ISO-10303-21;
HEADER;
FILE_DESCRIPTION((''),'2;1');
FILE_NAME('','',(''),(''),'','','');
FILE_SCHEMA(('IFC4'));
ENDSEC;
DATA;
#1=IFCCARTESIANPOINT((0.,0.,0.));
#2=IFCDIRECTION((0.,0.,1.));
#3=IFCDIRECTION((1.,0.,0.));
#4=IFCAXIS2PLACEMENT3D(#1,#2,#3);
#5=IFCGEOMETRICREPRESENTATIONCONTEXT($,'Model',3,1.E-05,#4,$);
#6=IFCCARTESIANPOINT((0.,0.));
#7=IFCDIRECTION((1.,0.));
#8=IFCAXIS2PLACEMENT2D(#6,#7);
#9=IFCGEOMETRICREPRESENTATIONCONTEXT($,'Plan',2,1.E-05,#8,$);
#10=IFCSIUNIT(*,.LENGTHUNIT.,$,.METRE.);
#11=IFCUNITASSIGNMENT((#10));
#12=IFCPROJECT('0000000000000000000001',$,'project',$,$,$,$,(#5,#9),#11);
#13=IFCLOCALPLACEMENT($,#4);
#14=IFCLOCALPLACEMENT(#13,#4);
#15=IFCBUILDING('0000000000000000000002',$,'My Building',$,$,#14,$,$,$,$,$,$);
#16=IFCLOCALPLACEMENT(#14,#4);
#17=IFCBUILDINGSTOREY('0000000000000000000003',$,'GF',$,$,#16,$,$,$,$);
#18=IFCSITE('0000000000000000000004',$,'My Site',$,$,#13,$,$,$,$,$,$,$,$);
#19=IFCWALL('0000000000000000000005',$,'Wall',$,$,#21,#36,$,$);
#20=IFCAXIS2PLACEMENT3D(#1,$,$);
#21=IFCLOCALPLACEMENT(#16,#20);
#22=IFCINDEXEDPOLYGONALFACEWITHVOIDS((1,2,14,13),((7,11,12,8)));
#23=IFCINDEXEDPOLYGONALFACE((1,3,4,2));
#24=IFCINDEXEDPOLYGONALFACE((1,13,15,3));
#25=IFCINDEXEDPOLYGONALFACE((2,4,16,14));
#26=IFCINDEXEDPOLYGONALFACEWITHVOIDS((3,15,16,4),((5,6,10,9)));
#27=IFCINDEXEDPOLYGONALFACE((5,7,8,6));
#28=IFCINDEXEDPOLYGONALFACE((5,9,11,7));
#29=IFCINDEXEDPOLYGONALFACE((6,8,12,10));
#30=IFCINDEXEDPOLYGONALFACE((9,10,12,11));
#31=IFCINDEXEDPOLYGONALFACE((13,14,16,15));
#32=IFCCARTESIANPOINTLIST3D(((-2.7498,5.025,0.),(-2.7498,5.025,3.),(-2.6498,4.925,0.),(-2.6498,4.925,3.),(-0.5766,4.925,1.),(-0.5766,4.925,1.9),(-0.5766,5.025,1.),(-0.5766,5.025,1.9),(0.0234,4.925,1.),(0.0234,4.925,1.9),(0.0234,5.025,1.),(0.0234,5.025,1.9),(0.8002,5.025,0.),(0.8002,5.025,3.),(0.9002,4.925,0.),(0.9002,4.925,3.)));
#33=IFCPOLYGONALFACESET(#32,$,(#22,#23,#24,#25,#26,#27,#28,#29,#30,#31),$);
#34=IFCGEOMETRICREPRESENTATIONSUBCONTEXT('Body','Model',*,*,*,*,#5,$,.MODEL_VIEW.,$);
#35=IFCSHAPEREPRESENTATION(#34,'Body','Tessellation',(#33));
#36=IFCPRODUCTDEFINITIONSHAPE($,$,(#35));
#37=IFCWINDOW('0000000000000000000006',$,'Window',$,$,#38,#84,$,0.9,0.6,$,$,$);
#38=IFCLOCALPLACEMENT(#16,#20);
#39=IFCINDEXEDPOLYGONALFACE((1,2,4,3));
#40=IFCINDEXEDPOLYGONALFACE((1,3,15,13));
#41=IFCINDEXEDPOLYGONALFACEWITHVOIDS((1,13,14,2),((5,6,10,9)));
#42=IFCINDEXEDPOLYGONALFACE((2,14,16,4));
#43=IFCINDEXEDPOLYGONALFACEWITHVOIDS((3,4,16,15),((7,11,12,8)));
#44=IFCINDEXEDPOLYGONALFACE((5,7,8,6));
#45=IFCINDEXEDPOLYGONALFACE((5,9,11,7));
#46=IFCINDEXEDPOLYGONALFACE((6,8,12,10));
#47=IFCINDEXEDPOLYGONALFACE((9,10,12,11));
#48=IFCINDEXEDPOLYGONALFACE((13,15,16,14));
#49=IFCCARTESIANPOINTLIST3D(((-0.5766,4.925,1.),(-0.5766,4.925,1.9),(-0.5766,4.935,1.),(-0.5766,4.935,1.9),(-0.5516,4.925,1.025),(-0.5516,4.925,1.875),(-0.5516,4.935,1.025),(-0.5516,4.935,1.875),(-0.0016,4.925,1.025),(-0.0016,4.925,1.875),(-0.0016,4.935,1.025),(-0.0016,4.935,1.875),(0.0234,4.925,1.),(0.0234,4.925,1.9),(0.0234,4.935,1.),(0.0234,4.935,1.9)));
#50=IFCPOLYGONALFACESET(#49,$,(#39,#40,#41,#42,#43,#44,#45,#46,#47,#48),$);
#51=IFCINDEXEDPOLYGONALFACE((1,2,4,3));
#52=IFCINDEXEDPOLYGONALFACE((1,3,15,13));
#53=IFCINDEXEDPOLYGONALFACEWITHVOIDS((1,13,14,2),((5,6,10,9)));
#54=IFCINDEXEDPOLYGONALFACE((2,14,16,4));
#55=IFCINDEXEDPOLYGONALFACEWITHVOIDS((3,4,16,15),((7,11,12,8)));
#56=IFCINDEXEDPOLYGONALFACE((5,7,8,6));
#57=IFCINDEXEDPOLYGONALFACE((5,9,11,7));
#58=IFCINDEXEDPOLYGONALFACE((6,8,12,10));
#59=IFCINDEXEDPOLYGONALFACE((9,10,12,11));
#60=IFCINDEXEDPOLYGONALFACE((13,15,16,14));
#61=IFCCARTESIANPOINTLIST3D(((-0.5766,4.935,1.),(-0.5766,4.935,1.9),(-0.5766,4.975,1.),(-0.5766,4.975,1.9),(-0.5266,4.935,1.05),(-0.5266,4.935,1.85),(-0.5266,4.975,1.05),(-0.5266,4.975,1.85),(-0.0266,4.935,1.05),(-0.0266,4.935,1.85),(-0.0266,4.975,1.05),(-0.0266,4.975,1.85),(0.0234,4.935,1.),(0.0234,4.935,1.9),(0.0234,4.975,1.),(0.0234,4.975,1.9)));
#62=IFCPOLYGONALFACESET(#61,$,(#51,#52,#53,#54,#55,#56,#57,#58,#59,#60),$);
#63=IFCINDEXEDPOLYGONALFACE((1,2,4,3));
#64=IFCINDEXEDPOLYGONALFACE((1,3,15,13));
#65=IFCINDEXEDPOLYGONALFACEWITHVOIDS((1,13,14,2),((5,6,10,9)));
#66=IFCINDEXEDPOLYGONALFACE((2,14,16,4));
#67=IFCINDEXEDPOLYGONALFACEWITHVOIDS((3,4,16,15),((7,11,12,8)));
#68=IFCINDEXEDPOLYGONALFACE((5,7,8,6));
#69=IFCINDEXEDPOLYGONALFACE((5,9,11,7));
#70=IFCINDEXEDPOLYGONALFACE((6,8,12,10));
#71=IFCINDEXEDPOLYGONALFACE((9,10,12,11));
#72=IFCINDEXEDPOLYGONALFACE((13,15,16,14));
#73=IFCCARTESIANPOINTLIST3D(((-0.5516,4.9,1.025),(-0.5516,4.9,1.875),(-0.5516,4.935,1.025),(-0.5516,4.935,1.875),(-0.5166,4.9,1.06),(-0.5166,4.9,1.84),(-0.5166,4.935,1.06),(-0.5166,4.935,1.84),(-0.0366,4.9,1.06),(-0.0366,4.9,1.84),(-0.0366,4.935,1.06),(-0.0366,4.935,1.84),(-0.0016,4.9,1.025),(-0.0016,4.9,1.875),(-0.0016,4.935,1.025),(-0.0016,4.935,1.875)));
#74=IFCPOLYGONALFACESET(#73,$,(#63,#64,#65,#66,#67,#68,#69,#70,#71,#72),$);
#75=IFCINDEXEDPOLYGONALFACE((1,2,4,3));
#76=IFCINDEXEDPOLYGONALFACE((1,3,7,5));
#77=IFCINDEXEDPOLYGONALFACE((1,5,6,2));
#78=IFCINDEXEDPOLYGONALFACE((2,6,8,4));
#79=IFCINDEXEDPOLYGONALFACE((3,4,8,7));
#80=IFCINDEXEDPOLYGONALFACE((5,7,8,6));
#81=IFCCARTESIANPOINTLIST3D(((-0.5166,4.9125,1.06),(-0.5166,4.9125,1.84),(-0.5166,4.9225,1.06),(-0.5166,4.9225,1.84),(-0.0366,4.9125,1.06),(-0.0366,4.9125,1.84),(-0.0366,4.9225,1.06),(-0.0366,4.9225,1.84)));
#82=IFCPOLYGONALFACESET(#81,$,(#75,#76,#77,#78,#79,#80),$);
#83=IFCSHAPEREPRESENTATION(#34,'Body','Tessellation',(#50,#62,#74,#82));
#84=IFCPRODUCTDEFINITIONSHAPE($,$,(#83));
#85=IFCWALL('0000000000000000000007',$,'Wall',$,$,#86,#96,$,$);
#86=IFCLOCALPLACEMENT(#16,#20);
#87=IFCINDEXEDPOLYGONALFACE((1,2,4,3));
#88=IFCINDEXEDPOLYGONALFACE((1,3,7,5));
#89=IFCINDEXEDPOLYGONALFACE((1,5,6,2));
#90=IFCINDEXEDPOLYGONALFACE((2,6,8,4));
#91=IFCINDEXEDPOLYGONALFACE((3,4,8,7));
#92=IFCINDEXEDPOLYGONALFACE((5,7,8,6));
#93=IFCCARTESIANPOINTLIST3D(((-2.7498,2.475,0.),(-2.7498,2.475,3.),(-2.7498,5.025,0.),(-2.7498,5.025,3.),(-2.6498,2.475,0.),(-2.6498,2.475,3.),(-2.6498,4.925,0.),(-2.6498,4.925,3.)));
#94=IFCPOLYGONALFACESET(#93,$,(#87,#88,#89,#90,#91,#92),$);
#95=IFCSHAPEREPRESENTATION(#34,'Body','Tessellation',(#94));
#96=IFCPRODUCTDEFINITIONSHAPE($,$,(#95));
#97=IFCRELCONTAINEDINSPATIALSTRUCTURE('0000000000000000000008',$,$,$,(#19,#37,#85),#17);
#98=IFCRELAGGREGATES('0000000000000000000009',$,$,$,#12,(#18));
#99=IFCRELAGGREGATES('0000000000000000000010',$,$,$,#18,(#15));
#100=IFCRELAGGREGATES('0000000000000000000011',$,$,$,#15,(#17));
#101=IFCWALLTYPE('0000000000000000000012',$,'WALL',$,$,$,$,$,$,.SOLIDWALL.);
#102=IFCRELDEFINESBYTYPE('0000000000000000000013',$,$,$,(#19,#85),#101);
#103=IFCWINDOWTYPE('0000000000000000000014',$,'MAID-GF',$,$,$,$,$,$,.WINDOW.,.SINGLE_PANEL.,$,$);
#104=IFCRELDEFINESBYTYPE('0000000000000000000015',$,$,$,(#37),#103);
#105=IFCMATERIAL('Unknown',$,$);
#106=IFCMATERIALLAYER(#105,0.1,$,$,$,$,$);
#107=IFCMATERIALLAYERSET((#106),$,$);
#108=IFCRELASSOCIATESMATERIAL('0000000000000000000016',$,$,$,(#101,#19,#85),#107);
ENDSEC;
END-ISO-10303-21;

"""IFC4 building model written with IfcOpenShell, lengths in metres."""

from ifc_helpers import new_model, entity, si_unit, frame, origin_with_axes, origin_2d_with_axis, place, context, subcontext, project, spatial, line, indexed_curve, outline, extrude, shape, source, transform, mapped, material, layer, layer_set, layer_usage, type_object, type_shapes, element, fill, save


model = new_model("IFC4")

# Units and contexts
model_context = context("Model", 3, precision=1e-05, world=origin_with_axes())
plan_context = context("Plan", 2, precision=1e-05, world=origin_2d_with_axis())
body_context_1 = subcontext(model_context, "Body", "Model", "MODEL_VIEW")
body_context_2 = subcontext(plan_context, "Body", "Plan", "PLAN_VIEW")
ifc_project = project(units=[si_unit("LENGTHUNIT", "METRE")], contexts=[model_context, plan_context])

# Site, building, storey
site_placement = place(None, origin_with_axes())
site = spatial("IfcSite", under=ifc_project, at=site_placement, Name="My Site")
building_placement = place(site_placement, origin_with_axes())
building = spatial("IfcBuilding", under=site, at=building_placement, Name="My Building")
storey_placement = place(building_placement, origin_with_axes())
storey = spatial("IfcBuildingStorey", under=building, at=storey_placement, Name="GF")

# Shared definitions
ifc_material_1 = material(Name="Unknown")

# Wall, opening, window
ifc_layer_1 = layer(ifc_material_1, 0.1)
ifc_layer_set_1 = layer_set([ifc_layer_1])
ifc_layer_usage_1 = layer_usage(ifc_layer_set_1, "AXIS2", "POSITIVE", 0.0)
wall_type = type_object("IfcWallType", Name="WALL", PredefinedType="SOLIDWALL", material=ifc_layer_set_1)
wall_1_placement = place(storey_placement, frame((0.8002, 5.025, 0.0), z_axis=(0.0, 0.0, 1.0), x_axis=(-1.0, 0.0, 0.0)))
wall_1 = element("IfcWall", 1, at=wall_1_placement, inside=storey, type_object=wall_type, material=ifc_layer_usage_1, Name="Wall", context=body_context_1, shape_type="SweptSolid", body=[
    extrude(outline(indexed_curve([(0.0, 0.0), (-0.1, 0.1), (3.45, 0.1), (3.55, 0.0)], segments=[line(1, 2, 3, 4, 1)])), origin_with_axes(), (0.0, 0.0, 1.0), 3.0),
])
shared_shape_1 = source(origin_with_axes(), body_context_1, "Body", "SweptSolid", [
    extrude(outline(indexed_curve([(0.0, 0.0), (0.6, 0.0), (0.6, 0.9), (0.0, 0.9)], segments=[line(1, 2, 3, 4, 1)])), frame((0.0, -0.6, 0.0), z_axis=(0.0, -1.0, 0.0), x_axis=(1.0, 0.0, 0.0)), (0.0, 0.0, -1.0), 1.2),
])
opening_1_placement = place(wall_1_placement, frame((0.7768, 0.0, 1.0), z_axis=(0.0, 0.0, 1.0), x_axis=(1.0, -0.000001, 0.0)))
opening_1 = element("IfcOpeningElement", 2, at=opening_1_placement, cuts=wall_1, PredefinedType="OPENING", context=body_context_1, shape_type="MappedRepresentation", body=[
    mapped(shared_shape_1, transform((0.0, 0.0, 0.0), x_axis=(1.0, 0.0, 0.0), y_axis=(0.0, 1.0, 0.0), z_axis=(0.0, 0.0, 1.0), scale=1.0)),
])
window_type_1 = type_object("IfcWindowType", Name="MAID-GF", PartitioningType="SINGLE_PANEL", PredefinedType="WINDOW")
shared_shape_2 = source(origin_with_axes(), body_context_1, "Body", "SweptSolid", [
    extrude(outline(indexed_curve([(0.0, 0.0), (0.6, 0.0), (0.6, 0.9), (0.0, 0.9)], segments=[line(1, 2, 3, 4, 1)]), holes=[indexed_curve([(0.025, 0.025), (0.575, 0.025), (0.575, 0.875), (0.025, 0.875)], segments=[line(1, 2, 3, 4, 1)])]), frame((0.0, 0.09, 0.0), z_axis=(0.0, -1.0, 0.0), x_axis=(1.0, 0.0, 0.0)), (0.0, 0.0, -1.0), 0.01),
    extrude(outline(indexed_curve([(0.0, 0.0), (0.6, 0.0), (0.6, 0.9), (0.0, 0.9)], segments=[line(1, 2, 3, 4, 1)]), holes=[indexed_curve([(0.05, 0.05), (0.55, 0.05), (0.55, 0.85), (0.05, 0.85)], segments=[line(1, 2, 3, 4, 1)])]), frame((0.0, 0.05, 0.0), z_axis=(0.0, -1.0, 0.0), x_axis=(1.0, 0.0, 0.0)), (0.0, 0.0, -1.0), 0.04),
    extrude(outline(indexed_curve([(0.0, 0.0), (0.55, 0.0), (0.55, 0.85), (0.0, 0.85)], segments=[line(1, 2, 3, 4, 1)]), holes=[indexed_curve([(0.035, 0.035), (0.515, 0.035), (0.515, 0.815), (0.035, 0.815)], segments=[line(1, 2, 3, 4, 1)])]), frame((0.025, 0.09, 0.025), z_axis=(0.0, -1.0, 0.0), x_axis=(1.0, 0.0, 0.0)), (0.0, 0.0, -1.0), 0.035),
    extrude(outline(indexed_curve([(0.035, 0.035), (0.515, 0.035), (0.515, 0.815), (0.035, 0.815)], segments=[line(1, 2, 3, 4, 1)])), frame((0.025, 0.1025, 0.025), z_axis=(0.0, -1.0, 0.0), x_axis=(1.0, 0.0, 0.0)), (0.0, 0.0, -1.0), 0.01),
])
shared_shape_3 = source(origin_with_axes(), body_context_2, "Body", "Curve2D", [
    entity("IfcIndexedPolyCurve", entity("IfcCartesianPointList2D", [[0.05, 0.05], [0.55, 0.05]])),
    entity("IfcIndexedPolyCurve", entity("IfcCartesianPointList2D", [[0.0, 0.1], [0.025, 0.1], [0.025, 0.09], [0.05, 0.09], [0.05, 0.05], [0.0, 0.05]]), [entity("IfcLineIndex", [1, 2, 3, 4, 5, 6, 1])]),
    entity("IfcIndexedPolyCurve", entity("IfcCartesianPointList2D", [[0.6, 0.1], [0.575, 0.1], [0.575, 0.09], [0.55, 0.09], [0.55, 0.05], [0.6, 0.05]]), [entity("IfcLineIndex", [1, 2, 3, 4, 5, 6, 1])]),
    entity("IfcIndexedPolyCurve", entity("IfcCartesianPointList2D", [[0.025, 0.09], [0.06, 0.09], [0.06, 0.125], [0.025, 0.125]]), [entity("IfcLineIndex", [1, 2, 3, 4, 1])]),
    entity("IfcIndexedPolyCurve", entity("IfcCartesianPointList2D", [[0.575, 0.09], [0.54, 0.09], [0.54, 0.125], [0.575, 0.125]]), [entity("IfcLineIndex", [1, 2, 3, 4, 1])]),
    entity("IfcIndexedPolyCurve", entity("IfcCartesianPointList2D", [[0.06, 0.09], [0.54, 0.09]])),
    entity("IfcIndexedPolyCurve", entity("IfcCartesianPointList2D", [[0.06, 0.125], [0.54, 0.125]])),
    entity("IfcIndexedPolyCurve", entity("IfcCartesianPointList2D", [[0.06, 0.1075], [0.54, 0.1075]])),
])
type_shapes(window_type_1, [shared_shape_2, shared_shape_3])
window_1_placement = place(opening_1_placement, frame((0.0, 0.0, 0.0), z_axis=(0.0, 0.0, 1.0), x_axis=(1.0, 0.0, 0.0)))
window_1 = element("IfcWindow", 3, at=window_1_placement, inside=storey, type_object=window_type_1, Name="Window", OverallHeight=0.9, OverallWidth=0.6, shapes=[
    shape(body_context_1, "Body", "MappedRepresentation", [mapped(shared_shape_2, transform((0.0, 0.0, 0.0), x_axis=(1.0, 0.0, 0.0), y_axis=(0.0, 1.0, 0.0), z_axis=(0.0, 0.0, 1.0), scale=1.0))]),
    shape(body_context_2, "Body", "MappedRepresentation", [mapped(shared_shape_3, transform((0.0, 0.0, 0.0), x_axis=(1.0, 0.0, 0.0), y_axis=(0.0, 1.0, 0.0), z_axis=(0.0, 0.0, 1.0), scale=1.0))]),
])
fill(opening_1, window_1)

# Wall
ifc_layer_usage_2 = layer_usage(ifc_layer_set_1, "AXIS2", "POSITIVE", 0.0)
wall_2_placement = place(storey_placement, frame((-2.7498, 5.025, 0.0), z_axis=(0.0, 0.0, 1.0), x_axis=(0.0, -1.0, 0.0)))
element("IfcWall", 4, at=wall_2_placement, inside=storey, type_object=wall_type, material=ifc_layer_usage_2, Name="Wall", context=body_context_1, shape_type="SweptSolid", body=[
    extrude(outline(indexed_curve([(0.0, 0.0), (0.1, 0.1), (2.55, 0.1), (2.55, 0.0)], segments=[line(1, 2, 3, 4, 1)])), origin_with_axes(), (0.0, 0.0, 1.0), 3.0),
])

save(model, "model.ifc")
